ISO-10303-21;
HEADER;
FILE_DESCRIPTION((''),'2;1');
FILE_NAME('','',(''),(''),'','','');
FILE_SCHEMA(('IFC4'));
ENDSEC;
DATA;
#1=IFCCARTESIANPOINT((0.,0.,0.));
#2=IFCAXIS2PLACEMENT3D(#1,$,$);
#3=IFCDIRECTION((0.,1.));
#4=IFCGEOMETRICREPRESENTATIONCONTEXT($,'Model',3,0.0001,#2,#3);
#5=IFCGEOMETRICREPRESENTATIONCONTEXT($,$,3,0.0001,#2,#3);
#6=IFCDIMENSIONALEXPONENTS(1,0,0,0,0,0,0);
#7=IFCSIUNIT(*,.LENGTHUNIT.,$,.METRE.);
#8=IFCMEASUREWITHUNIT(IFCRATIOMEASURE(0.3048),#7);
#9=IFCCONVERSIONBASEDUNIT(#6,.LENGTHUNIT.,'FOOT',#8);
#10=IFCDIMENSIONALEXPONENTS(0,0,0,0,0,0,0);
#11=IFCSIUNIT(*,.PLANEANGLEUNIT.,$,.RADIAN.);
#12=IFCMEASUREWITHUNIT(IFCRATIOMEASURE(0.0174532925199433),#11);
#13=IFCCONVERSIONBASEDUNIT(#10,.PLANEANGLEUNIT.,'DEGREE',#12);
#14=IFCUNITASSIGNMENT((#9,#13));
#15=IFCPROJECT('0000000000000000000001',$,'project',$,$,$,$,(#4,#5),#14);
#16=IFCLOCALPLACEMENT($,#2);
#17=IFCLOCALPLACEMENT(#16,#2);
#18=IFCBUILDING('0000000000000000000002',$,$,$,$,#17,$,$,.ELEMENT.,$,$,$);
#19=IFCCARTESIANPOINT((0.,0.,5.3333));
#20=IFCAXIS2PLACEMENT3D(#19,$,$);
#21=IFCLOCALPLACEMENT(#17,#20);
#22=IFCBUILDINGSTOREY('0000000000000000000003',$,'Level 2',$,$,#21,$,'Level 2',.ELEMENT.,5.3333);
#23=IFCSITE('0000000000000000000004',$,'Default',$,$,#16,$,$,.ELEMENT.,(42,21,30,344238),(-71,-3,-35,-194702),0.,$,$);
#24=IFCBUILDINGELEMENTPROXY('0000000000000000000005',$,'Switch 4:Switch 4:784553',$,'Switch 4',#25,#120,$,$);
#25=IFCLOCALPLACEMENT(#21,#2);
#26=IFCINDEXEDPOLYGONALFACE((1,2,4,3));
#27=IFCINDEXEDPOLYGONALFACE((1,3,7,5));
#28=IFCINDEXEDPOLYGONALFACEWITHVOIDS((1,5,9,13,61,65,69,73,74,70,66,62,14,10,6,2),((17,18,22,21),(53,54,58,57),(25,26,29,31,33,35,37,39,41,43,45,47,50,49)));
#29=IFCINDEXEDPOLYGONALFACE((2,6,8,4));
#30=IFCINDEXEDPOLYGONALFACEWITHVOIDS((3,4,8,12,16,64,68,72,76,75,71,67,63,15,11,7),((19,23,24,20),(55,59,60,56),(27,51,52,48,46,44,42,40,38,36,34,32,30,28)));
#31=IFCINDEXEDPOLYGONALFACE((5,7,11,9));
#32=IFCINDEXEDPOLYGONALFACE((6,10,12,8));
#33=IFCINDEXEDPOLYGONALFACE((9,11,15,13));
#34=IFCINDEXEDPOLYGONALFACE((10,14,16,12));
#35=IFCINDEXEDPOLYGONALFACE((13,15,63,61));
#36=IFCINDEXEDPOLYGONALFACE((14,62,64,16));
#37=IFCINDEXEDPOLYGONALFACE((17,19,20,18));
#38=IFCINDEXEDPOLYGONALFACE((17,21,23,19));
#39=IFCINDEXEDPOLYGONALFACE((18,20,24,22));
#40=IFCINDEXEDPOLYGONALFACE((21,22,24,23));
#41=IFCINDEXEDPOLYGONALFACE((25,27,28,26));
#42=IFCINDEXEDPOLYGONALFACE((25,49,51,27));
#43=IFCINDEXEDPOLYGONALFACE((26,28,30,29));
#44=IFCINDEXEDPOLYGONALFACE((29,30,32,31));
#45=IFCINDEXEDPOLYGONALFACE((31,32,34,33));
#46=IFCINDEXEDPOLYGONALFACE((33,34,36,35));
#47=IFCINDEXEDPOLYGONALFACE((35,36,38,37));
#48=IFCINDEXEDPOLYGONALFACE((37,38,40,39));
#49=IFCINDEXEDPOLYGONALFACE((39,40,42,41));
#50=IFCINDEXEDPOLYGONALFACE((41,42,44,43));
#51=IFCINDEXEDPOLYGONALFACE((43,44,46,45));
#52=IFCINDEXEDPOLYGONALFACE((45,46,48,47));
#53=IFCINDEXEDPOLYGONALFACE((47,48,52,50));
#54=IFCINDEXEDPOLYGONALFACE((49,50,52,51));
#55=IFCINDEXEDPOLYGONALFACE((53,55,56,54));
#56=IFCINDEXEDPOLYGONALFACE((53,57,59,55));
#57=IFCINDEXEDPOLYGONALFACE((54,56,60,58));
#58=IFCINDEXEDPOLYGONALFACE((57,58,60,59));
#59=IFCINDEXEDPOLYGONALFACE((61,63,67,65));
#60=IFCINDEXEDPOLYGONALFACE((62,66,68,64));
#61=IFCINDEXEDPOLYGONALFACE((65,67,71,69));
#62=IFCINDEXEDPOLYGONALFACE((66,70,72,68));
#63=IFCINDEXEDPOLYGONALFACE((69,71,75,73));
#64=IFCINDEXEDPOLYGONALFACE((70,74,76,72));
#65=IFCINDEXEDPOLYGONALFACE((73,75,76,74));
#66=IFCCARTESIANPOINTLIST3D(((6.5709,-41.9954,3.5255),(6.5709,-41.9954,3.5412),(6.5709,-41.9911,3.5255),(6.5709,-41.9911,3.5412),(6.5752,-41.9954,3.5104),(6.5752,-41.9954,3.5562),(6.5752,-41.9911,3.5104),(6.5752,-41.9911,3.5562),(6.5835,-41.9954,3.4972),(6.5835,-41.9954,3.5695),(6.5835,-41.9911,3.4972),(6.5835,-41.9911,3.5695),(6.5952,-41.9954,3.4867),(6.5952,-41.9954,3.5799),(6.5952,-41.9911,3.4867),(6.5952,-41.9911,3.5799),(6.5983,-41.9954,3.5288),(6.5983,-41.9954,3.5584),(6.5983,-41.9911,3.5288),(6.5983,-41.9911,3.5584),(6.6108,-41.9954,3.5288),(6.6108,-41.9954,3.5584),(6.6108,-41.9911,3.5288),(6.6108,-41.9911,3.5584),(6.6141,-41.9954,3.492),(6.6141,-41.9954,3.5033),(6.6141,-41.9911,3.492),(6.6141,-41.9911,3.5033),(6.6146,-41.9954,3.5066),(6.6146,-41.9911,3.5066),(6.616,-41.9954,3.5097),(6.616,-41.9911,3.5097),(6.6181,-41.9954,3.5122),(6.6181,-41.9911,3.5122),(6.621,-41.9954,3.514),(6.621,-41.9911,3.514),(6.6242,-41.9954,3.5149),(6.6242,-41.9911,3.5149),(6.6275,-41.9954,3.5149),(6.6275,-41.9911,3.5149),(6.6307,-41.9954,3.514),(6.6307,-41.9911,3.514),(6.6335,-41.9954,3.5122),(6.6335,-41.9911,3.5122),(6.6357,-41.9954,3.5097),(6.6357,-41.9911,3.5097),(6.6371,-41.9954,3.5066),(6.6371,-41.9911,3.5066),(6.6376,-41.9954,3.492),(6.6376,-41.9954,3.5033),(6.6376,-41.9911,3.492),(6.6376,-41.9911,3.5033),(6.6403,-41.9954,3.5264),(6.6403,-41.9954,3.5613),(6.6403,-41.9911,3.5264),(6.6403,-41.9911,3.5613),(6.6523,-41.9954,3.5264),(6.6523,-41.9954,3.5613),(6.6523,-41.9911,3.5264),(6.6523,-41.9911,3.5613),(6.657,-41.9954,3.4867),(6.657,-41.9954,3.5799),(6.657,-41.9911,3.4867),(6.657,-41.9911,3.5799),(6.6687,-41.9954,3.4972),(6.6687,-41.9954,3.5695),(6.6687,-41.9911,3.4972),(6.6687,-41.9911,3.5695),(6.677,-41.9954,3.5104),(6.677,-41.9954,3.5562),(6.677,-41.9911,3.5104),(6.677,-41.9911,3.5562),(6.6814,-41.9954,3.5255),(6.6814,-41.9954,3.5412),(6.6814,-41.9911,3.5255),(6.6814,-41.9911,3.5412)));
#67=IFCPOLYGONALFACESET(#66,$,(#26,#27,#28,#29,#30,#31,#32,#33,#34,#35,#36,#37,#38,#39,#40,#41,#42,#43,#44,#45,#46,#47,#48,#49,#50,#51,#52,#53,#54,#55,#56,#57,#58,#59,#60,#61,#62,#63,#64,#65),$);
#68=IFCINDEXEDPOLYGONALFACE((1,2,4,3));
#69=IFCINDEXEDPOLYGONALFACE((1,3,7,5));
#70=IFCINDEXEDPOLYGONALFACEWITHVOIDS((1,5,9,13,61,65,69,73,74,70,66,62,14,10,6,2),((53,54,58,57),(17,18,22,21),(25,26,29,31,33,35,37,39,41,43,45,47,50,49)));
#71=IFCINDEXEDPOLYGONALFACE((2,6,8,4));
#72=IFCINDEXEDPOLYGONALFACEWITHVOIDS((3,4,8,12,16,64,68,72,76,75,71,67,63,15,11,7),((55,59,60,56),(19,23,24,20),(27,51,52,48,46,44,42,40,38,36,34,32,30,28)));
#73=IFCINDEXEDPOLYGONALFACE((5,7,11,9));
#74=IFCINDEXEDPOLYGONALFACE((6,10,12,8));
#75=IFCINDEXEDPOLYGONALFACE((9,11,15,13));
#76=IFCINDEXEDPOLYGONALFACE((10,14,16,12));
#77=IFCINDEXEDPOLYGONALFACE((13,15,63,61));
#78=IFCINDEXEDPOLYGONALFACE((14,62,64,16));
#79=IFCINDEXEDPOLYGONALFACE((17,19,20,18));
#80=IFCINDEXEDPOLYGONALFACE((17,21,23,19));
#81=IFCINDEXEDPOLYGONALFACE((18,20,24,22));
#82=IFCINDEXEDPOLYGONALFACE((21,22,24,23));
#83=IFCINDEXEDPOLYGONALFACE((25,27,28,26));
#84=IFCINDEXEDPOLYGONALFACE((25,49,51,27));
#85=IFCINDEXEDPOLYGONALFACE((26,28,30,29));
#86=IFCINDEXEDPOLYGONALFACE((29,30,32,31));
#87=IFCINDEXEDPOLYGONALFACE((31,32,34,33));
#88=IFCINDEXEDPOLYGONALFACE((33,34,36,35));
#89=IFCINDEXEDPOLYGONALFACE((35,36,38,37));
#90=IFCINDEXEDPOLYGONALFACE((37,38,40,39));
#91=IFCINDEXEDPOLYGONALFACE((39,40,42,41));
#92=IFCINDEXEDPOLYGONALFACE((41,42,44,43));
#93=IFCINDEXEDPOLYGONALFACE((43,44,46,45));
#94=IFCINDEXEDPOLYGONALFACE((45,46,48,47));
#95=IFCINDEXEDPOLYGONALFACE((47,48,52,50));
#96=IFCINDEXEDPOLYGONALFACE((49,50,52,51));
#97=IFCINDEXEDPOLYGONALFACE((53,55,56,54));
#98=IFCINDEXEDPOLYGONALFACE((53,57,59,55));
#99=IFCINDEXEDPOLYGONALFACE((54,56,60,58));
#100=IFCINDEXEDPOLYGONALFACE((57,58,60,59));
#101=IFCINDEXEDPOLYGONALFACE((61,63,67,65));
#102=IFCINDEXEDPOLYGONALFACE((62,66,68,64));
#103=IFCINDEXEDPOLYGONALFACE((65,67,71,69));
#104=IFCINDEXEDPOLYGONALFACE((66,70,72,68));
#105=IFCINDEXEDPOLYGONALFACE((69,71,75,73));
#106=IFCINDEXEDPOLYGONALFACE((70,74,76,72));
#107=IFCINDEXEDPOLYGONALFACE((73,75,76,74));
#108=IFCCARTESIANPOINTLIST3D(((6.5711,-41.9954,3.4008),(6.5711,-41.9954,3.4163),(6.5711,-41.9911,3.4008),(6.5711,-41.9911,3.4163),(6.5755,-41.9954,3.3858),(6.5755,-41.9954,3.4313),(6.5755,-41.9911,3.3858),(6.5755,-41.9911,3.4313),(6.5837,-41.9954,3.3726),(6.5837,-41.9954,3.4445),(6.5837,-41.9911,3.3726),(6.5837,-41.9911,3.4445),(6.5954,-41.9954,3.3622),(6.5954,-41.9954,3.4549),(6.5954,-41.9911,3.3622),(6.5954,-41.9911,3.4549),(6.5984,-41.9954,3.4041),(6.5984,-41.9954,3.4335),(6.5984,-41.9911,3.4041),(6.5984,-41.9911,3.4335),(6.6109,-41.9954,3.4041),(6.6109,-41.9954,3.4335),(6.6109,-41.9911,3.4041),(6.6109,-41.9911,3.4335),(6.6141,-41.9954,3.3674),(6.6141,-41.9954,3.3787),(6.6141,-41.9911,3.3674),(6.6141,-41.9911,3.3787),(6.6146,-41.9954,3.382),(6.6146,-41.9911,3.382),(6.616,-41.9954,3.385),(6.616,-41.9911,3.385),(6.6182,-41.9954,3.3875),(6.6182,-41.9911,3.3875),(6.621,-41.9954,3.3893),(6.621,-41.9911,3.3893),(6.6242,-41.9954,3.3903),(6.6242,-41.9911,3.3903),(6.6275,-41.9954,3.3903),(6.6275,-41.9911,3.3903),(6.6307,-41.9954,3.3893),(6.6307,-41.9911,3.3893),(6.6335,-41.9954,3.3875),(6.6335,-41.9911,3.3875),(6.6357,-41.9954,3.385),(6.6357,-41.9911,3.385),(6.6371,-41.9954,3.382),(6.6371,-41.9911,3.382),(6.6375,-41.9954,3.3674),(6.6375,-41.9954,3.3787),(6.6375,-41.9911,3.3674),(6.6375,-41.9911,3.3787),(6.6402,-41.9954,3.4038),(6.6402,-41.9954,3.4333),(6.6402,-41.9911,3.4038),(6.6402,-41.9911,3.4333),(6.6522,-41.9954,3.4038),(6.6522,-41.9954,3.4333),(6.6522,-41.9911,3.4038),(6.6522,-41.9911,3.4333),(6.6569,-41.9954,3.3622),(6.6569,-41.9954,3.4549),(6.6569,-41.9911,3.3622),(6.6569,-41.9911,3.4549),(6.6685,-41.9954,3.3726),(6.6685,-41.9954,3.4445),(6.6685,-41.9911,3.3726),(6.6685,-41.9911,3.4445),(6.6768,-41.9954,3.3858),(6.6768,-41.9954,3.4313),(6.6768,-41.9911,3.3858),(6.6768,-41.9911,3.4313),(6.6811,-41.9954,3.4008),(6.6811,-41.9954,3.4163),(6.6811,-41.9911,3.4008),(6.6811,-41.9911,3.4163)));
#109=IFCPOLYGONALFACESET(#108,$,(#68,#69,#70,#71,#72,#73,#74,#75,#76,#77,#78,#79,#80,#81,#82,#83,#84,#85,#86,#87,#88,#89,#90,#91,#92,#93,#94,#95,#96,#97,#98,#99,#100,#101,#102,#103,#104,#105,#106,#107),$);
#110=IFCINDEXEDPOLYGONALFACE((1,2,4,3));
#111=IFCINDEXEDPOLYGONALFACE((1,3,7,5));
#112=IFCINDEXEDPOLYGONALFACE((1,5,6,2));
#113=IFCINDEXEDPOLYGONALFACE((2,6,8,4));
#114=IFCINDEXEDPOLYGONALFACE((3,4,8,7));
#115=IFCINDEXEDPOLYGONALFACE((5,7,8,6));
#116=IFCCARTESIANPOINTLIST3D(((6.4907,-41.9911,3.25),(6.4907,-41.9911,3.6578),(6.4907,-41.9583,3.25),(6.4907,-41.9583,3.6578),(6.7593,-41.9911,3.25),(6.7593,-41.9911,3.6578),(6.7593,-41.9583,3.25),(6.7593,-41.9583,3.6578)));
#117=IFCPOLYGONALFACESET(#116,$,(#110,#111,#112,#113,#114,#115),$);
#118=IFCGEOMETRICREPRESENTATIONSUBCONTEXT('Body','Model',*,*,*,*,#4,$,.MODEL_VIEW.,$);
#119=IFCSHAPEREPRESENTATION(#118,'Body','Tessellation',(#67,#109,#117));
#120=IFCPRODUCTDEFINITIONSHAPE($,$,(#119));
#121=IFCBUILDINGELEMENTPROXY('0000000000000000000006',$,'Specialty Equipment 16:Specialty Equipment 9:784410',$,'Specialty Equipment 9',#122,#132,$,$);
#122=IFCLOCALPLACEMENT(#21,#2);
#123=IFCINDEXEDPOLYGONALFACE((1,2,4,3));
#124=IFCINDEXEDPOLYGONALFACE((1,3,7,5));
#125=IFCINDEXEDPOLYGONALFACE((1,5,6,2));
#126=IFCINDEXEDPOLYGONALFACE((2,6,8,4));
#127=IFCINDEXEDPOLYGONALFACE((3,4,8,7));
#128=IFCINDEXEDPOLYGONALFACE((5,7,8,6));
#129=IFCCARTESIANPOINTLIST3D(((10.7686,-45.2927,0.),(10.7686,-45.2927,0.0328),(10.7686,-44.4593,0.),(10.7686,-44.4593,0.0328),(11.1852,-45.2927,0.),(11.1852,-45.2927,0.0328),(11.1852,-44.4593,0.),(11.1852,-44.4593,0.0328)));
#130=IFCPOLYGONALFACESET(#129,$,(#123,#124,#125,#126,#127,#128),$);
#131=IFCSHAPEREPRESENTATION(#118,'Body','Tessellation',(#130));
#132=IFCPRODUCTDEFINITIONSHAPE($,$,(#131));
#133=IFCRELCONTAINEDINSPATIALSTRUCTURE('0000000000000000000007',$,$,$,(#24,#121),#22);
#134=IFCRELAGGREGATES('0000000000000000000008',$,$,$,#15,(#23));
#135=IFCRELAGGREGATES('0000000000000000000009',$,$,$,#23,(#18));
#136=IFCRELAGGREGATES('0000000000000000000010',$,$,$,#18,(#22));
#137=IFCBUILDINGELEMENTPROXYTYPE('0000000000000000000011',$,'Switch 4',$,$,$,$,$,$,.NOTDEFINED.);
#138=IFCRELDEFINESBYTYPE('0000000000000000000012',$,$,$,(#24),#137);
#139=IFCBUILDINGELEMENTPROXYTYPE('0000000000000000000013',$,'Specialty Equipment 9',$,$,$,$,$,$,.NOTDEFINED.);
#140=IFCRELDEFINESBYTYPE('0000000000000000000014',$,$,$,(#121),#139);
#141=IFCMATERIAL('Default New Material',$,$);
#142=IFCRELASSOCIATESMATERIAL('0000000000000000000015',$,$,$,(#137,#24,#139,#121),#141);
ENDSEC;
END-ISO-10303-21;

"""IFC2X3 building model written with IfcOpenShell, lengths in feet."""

from ifc_helpers import new_model, entity, si_unit, converted_unit, direction, frame, frame_2d, origin, origin_2d_with_axis, place, context, subcontext, project, spatial, polyline, circle_curve, parameter, trimmed, segment, composite_curve, rectangle, outline, extrude, source, transform, mapped, material, type_object, type_shapes, element, save


model = new_model("IFC2X3")

# Units and contexts
model_context = context("Model", 3, precision=0.0001, world=origin(), true_north=direction((0.0, 1.0)))
context_of_model = context(None, 3, precision=0.0001, world=origin(), true_north=direction((0.0, 1.0)))
body_context = subcontext(model_context, "Body", "Model", "MODEL_VIEW")
ifc_project = project(units=[converted_unit("LENGTHUNIT", "FOOT", entity("IfcRatioMeasure", 0.3048), si_unit("LENGTHUNIT", "METRE"), dimensions=[1, 0, 0, 0, 0, 0, 0]), converted_unit("PLANEANGLEUNIT", "DEGREE", entity("IfcRatioMeasure", 0.0174532925199433), si_unit("PLANEANGLEUNIT", "RADIAN"), dimensions=[0, 0, 0, 0, 0, 0, 0])], contexts=[model_context, context_of_model])

# Site, building, storey
site_placement = place(None, origin())
site = spatial("IfcSite", under=ifc_project, at=site_placement, Name="Default", CompositionType="ELEMENT", RefLatitude=(42, 21, 30, 344238), RefLongitude=(-71, -3, -35, -194702), RefElevation=0.0)
building_placement = place(site_placement, origin())
building = spatial("IfcBuilding", under=site, at=building_placement, CompositionType="ELEMENT")
storey_placement = place(building_placement, frame((0.0, 0.0, 5.3333)))
storey = spatial("IfcBuildingStorey", under=building, at=storey_placement, Name="Level 2", LongName="Level 2", CompositionType="ELEMENT", Elevation=5.3333)

# Shared definitions
ifc_material = material(Name="Default New Material")

# Building element proxies
building_element_proxy_type_1 = type_object("IfcBuildingElementProxyType", Name="Switch 4", PredefinedType="NOTDEFINED", material=ifc_material)
shared_shape_1 = source(origin(), body_context, "Body", "SweptSolid", [
    extrude(outline(composite_curve([segment(polyline([(-0.0309, -0.0466), (0.0309, -0.0466)]), True, "CONTINUOUS"), segment(trimmed(circle_curve(frame_2d((-0.0003, 0.0), x_axis=(-1.0, 0.0)), 0.0561), [parameter(123.794741)], [parameter(236.205259)], True, "PARAMETER"), True, "CONTINUOUS"), segment(polyline([(0.0309, 0.0466), (-0.0309, 0.0466)]), True, "CONTINUOUS"), segment(trimmed(circle_curve(frame_2d((0.0003, 0.0), x_axis=(1.0, 0.0)), 0.0561), [parameter(123.794741)], [parameter(236.205259)], True, "PARAMETER"), True, "CONTINUOUS")], self_intersect=False), holes=[polyline([(0.0142, 0.0279), (0.0262, 0.0279), (0.0262, -0.0069), (0.0142, -0.0069), (0.0142, 0.0279)]), polyline([(-0.0153, 0.025), (-0.0153, -0.0045), (-0.0278, -0.0045), (-0.0278, 0.025), (-0.0153, 0.025)]), composite_curve([segment(polyline([(-0.012, -0.0413), (-0.012, -0.03)]), True, "CONTINUOUS"), segment(trimmed(circle_curve(frame_2d((-0.0003, -0.03), x_axis=(-1.0, 0.0)), 0.0117), [parameter(180.0)], [parameter(0.0)], True, "PARAMETER"), False, "CONTINUOUS"), segment(polyline([(0.0115, -0.03), (0.0115, -0.0413)]), True, "CONTINUOUS"), segment(polyline([(0.0115, -0.0413), (-0.012, -0.0413)]), True, "CONTINUOUS")], self_intersect=False)]), frame((-0.0011, 0.0328, 0.2833), z_axis=(0.0, 1.0, 0.0), x_axis=(-1.0, 0.0, 0.0)), (0.0, 0.0, 1.0), 0.0042),
    extrude(outline(composite_curve([segment(polyline([(-0.0308, -0.0464), (0.0308, -0.0464)]), True, "CONTINUOUS"), segment(trimmed(circle_curve(frame_2d((-0.0003, 0.0), x_axis=(-1.0, 0.0)), 0.0558), [parameter(123.794741)], [parameter(236.205259)], True, "PARAMETER"), True, "CONTINUOUS"), segment(polyline([(0.0308, 0.0464), (-0.0308, 0.0464)]), True, "CONTINUOUS"), segment(trimmed(circle_curve(frame_2d((0.0003, 0.0), x_axis=(1.0, 0.0)), 0.0558), [parameter(123.794741)], [parameter(236.205259)], True, "PARAMETER"), True, "CONTINUOUS")], self_intersect=False), holes=[polyline([(0.0141, 0.0247), (0.026, 0.0247), (0.026, -0.0047), (0.0141, -0.0047), (0.0141, 0.0247)]), polyline([(-0.0152, 0.0249), (-0.0152, -0.0045), (-0.0277, -0.0045), (-0.0277, 0.0249), (-0.0152, 0.0249)]), composite_curve([segment(polyline([(-0.012, -0.0411), (-0.012, -0.0299)]), True, "CONTINUOUS"), segment(trimmed(circle_curve(frame_2d((-0.0003, -0.0299), x_axis=(-1.0, 0.0)), 0.0117), [parameter(180.0)], [parameter(0.0)], True, "PARAMETER"), False, "CONTINUOUS"), segment(polyline([(0.0114, -0.0299), (0.0114, -0.0411)]), True, "CONTINUOUS"), segment(polyline([(0.0114, -0.0411), (-0.012, -0.0411)]), True, "CONTINUOUS")], self_intersect=False)]), frame((-0.0011, 0.0328, 0.1586), z_axis=(0.0, 1.0, 0.0), x_axis=(-1.0, 0.0, 0.0)), (0.0, 0.0, 1.0), 0.0042),
    extrude(rectangle(XDim=0.0328, YDim=0.2687, at=origin_2d_with_axis()), frame((0.0, 0.0164, 0.0), z_axis=(0.0, 0.0, 1.0), x_axis=(0.0, -1.0, 0.0)), (0.0, 0.0, 1.0), 0.4078),
])
type_shapes(building_element_proxy_type_1, [shared_shape_1])
proxy_1_placement = place(storey_placement, frame((6.625, -41.9583, 3.25), z_axis=(0.0, 0.0, 1.0), x_axis=(-1.0, 0.0, 0.0)))
element("IfcBuildingElementProxy", 1, at=proxy_1_placement, inside=storey, type_object=building_element_proxy_type_1, material=ifc_material, Name="Switch 4:Switch 4:784553", ObjectType="Switch 4", context=body_context, shape_type="MappedRepresentation", body=[
    mapped(shared_shape_1, transform((0.0, 0.0, 0.0), scale=1.0)),
])
building_element_proxy_type_2 = type_object("IfcBuildingElementProxyType", Name="Specialty Equipment 9", PredefinedType="NOTDEFINED", material=ifc_material)
shared_shape_2 = source(origin(), body_context, "Body", "SweptSolid", [
    extrude(rectangle(XDim=0.8333, YDim=0.4167, at=frame_2d((0.0, 0.0), x_axis=(1.0, 0.0))), frame((0.2083, 0.4167, 0.0), z_axis=(0.0, 0.0, 1.0), x_axis=(0.0, 1.0, 0.0)), (0.0, 0.0, 1.0), 0.0328),
])
type_shapes(building_element_proxy_type_2, [shared_shape_2])
proxy_2_placement = place(storey_placement, frame((10.7686, -45.2927, 0.0)))
element("IfcBuildingElementProxy", 2, at=proxy_2_placement, inside=storey, type_object=building_element_proxy_type_2, material=ifc_material, Name="Specialty Equipment 16:Specialty Equipment 9:784410", ObjectType="Specialty Equipment 9", context=body_context, shape_type="MappedRepresentation", body=[
    mapped(shared_shape_2, transform((0.0, 0.0, 0.0), scale=1.0)),
])

save(model, "model.ifc")
